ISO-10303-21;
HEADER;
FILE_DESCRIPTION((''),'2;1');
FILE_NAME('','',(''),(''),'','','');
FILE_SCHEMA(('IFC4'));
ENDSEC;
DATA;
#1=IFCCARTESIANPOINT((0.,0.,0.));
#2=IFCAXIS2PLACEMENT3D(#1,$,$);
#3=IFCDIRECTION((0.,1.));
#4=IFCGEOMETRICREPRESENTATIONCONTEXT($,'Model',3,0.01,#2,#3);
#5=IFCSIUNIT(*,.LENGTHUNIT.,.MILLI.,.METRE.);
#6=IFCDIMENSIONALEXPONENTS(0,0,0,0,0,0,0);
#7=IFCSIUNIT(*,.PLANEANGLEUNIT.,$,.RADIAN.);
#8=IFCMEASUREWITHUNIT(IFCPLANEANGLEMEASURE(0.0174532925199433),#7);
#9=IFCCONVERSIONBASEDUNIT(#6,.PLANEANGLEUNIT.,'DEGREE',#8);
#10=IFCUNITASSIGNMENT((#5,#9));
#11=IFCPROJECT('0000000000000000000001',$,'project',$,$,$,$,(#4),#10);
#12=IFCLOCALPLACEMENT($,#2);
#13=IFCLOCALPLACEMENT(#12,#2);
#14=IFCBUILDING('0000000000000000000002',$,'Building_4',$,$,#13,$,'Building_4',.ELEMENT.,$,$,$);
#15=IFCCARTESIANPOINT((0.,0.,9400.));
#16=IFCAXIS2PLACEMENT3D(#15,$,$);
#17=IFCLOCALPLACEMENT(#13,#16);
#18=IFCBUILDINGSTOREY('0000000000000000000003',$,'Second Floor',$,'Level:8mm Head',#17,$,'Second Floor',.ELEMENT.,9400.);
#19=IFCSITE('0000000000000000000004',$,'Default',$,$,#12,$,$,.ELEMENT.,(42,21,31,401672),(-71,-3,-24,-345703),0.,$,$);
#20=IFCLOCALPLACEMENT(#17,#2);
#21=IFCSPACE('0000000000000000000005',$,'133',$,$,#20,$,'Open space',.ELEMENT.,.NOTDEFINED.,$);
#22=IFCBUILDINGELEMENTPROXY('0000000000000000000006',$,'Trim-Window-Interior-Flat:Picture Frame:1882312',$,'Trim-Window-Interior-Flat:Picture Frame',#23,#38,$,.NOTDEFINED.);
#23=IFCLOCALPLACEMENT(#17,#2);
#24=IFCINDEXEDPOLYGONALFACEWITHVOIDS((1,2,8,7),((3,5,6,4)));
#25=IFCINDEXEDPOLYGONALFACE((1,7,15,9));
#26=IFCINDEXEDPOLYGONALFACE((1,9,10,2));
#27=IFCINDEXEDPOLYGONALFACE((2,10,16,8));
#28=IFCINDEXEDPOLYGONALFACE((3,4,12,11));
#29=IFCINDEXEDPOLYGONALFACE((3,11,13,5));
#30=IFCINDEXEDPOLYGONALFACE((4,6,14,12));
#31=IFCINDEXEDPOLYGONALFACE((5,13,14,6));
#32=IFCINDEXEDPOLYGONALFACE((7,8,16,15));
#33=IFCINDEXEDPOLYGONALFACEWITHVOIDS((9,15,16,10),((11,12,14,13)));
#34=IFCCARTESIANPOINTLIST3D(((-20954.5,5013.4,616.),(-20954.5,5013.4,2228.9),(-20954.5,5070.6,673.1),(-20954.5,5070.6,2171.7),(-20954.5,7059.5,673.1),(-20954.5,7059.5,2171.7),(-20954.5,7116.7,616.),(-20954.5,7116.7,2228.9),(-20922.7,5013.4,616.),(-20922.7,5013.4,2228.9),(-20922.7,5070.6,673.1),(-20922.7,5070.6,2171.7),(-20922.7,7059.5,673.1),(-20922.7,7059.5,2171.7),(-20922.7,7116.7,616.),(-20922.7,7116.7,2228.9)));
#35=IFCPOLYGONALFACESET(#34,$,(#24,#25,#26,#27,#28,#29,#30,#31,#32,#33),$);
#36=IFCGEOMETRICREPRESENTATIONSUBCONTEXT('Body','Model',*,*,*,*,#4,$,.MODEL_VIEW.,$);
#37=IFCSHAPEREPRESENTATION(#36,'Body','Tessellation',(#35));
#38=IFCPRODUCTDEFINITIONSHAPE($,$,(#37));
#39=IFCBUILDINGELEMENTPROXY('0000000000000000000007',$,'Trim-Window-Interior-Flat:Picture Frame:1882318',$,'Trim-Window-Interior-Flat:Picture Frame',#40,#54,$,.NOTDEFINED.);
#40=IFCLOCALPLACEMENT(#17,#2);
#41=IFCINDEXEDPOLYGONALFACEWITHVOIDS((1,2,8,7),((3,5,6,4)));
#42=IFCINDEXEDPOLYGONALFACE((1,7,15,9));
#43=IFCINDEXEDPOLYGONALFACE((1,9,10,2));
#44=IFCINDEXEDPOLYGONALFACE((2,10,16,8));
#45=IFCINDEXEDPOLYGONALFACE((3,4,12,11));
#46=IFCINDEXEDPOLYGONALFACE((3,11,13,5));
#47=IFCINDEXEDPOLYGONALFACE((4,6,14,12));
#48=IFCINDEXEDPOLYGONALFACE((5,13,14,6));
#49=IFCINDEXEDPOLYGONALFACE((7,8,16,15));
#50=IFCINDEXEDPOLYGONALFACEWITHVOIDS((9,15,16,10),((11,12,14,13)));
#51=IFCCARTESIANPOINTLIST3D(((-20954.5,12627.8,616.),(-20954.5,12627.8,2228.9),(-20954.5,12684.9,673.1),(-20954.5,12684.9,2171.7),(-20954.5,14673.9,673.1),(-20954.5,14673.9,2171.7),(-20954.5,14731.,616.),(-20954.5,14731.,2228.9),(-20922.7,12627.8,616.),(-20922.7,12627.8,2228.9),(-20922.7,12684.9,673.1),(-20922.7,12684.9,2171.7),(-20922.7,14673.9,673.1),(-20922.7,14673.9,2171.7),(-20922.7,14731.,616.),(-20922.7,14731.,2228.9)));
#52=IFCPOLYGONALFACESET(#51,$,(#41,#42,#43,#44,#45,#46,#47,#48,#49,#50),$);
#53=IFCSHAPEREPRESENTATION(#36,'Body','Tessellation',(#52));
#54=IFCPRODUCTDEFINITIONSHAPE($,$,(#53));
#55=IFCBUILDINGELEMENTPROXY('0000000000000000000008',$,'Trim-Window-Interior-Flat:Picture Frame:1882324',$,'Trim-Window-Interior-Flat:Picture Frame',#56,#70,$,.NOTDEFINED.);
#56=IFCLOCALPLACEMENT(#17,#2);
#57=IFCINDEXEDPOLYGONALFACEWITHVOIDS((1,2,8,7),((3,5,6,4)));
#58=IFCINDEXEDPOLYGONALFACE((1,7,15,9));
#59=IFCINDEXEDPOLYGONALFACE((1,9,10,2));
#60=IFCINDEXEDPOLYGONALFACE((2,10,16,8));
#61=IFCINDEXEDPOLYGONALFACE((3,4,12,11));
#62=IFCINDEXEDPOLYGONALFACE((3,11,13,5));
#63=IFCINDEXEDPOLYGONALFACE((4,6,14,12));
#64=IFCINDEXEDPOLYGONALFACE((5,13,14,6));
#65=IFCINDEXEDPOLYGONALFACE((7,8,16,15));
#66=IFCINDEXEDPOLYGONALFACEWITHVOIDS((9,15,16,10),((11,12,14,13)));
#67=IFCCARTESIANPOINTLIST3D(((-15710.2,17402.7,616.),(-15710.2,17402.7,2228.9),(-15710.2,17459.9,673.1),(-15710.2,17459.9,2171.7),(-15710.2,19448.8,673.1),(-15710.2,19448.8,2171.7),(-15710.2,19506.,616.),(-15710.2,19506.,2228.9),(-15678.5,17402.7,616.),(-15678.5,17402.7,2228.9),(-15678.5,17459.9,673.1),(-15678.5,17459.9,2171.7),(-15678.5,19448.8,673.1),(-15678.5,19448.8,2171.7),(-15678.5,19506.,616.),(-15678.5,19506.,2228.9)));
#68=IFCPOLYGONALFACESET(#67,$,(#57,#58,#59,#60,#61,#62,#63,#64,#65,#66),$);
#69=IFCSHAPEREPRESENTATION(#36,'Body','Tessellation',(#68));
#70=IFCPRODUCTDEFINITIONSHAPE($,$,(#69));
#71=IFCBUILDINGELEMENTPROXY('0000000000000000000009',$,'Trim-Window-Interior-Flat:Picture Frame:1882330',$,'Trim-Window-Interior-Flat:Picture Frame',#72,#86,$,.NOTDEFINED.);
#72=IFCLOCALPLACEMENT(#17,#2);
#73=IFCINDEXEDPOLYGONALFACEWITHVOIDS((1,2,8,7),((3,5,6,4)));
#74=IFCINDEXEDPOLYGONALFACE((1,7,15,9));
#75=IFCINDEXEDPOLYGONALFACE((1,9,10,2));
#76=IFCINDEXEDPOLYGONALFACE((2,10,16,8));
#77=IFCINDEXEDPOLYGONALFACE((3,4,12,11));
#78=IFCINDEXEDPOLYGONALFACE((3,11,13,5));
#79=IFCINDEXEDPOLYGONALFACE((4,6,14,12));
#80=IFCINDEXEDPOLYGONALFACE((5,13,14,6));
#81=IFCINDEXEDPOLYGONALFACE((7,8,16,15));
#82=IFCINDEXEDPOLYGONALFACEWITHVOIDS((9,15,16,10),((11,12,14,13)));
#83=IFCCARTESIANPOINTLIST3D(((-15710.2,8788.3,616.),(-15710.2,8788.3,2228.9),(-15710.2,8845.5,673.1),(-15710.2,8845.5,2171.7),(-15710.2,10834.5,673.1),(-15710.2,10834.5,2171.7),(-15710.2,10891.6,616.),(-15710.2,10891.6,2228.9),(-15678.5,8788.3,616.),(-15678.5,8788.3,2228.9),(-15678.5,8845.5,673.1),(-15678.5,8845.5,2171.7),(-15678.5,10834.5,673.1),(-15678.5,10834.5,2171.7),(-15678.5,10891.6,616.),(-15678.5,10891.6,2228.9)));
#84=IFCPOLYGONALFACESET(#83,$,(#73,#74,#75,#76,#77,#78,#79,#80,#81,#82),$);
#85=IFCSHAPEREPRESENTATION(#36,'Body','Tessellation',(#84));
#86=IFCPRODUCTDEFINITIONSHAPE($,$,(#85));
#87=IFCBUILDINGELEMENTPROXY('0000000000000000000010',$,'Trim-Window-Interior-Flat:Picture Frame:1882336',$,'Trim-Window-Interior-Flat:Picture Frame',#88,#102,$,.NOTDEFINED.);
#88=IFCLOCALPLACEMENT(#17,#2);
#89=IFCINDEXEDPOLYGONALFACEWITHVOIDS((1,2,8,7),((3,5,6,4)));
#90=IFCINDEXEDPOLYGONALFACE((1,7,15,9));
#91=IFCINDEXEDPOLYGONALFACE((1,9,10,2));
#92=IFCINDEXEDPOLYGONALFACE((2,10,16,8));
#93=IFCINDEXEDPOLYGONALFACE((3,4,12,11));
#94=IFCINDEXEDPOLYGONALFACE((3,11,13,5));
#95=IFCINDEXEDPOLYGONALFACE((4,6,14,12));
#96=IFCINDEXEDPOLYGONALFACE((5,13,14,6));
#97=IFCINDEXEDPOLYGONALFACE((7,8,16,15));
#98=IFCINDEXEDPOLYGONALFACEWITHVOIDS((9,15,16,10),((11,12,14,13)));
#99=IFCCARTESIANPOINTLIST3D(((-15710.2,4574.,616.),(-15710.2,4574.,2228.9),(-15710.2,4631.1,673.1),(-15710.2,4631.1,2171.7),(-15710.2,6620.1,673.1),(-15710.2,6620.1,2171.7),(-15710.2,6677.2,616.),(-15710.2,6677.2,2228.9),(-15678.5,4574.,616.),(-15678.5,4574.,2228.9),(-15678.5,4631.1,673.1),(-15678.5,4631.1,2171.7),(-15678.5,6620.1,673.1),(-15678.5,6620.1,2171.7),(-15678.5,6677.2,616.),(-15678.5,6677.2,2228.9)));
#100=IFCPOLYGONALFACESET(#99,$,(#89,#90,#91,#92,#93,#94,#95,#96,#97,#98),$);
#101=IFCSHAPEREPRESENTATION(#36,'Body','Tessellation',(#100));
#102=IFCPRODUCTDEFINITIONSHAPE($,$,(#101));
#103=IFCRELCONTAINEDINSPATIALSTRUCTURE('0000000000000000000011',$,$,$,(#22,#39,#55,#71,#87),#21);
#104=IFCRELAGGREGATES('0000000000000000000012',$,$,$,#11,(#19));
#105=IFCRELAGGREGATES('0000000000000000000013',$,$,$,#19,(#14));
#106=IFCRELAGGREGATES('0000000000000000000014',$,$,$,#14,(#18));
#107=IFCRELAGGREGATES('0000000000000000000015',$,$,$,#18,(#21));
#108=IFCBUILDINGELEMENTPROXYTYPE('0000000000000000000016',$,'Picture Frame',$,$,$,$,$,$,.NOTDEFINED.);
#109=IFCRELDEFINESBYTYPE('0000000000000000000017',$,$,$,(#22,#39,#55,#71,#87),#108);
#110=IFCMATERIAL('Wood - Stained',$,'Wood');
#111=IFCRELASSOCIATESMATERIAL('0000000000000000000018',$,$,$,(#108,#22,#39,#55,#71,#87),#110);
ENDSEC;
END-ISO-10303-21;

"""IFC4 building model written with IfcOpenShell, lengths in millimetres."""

from ifc_helpers import new_model, entity, si_unit, converted_unit, direction, frame, origin, place, context, subcontext, project, spatial, indexed_curve, outline, extrude, source, transform, mapped, material, type_object, type_shapes, element, save


model = new_model("IFC4")

# Units and contexts
model_context = context("Model", 3, precision=0.01, world=origin(), true_north=direction((0.0, 1.0)))
body_context = subcontext(model_context, "Body", "Model", "MODEL_VIEW")
ifc_project = project(units=[si_unit("LENGTHUNIT", "METRE", prefix="MILLI"), converted_unit("PLANEANGLEUNIT", "DEGREE", entity("IfcPlaneAngleMeasure", 0.0174532925199433), si_unit("PLANEANGLEUNIT", "RADIAN"), dimensions=[0, 0, 0, 0, 0, 0, 0])], contexts=[model_context])

# Site, building, storey
site_placement = place(None, origin())
site = spatial("IfcSite", under=ifc_project, at=site_placement, Name="Default", CompositionType="ELEMENT", RefLatitude=(42, 21, 31, 401672), RefLongitude=(-71, -3, -24, -345703), RefElevation=0.0)
building_placement = place(site_placement, origin())
building = spatial("IfcBuilding", under=site, at=building_placement, Name="Building_4", LongName="Building_4", CompositionType="ELEMENT")
storey_placement = place(building_placement, frame((0.0, 0.0, 9400.0)))
storey = spatial("IfcBuildingStorey", under=building, at=storey_placement, Name="Second Floor", ObjectType="Level:8mm Head", LongName="Second Floor", CompositionType="ELEMENT", Elevation=9400.0)

# Shared definitions
ifc_material_1 = material(Name="Wood - Stained", Category="Wood")

# Shared definitions
space_placement = place(storey_placement, origin())
space = spatial("IfcSpace", under=storey, at=space_placement, Name="133", LongName="Open space", CompositionType="ELEMENT", PredefinedType="NOTDEFINED")

# Building element proxies
building_element_proxy_type_1 = type_object("IfcBuildingElementProxyType", Name="Picture Frame", PredefinedType="NOTDEFINED", material=ifc_material_1)
shared_shape_1 = source(origin(), body_context, "Body", "SweptSolid", [
    extrude(outline(indexed_curve([(-1051.6, -806.4), (1051.6, -806.4), (1051.6, 806.4), (-1051.6, 806.4), (-1051.6, -806.4)], self_intersect=False), holes=[indexed_curve([(-994.5, -749.3), (-994.5, 749.3), (994.5, 749.3), (994.5, -749.3), (-994.5, -749.3)], self_intersect=False)]), frame((0.0, -762.0, 0.0), z_axis=(0.0, 0.0, 1.0), x_axis=(-1.0, 0.0, 0.0)), (0.0, 0.0, 1.0), 31.8),
])
type_shapes(building_element_proxy_type_1, [shared_shape_1])
for number, where, z_axis, x_axis, name in (
    (1, (-20954.5, 6065.0, 2184.4), (1.0, 0.0, 0.0), (0.0, 1.0, 0.0), "Trim-Window-Interior-Flat:Picture Frame:1882312"),
    (2, (-20954.5, 13679.4, 2184.4), (1.0, 0.0, 0.0), (0.0, 1.0, 0.0), "Trim-Window-Interior-Flat:Picture Frame:1882318"),
    (3, (-15678.5, 18454.3, 2184.4), (-1.0, 0.0, 0.0), (0.0, -1.0, 0.0), "Trim-Window-Interior-Flat:Picture Frame:1882324"),
    (4, (-15678.5, 9840.0, 2184.4), (-1.0, 0.0, 0.0), (0.0, -1.0, 0.0), "Trim-Window-Interior-Flat:Picture Frame:1882330"),
    (5, (-15678.5, 5625.6, 2184.4), (-1.0, 0.0, 0.0), (0.0, -1.0, 0.0), "Trim-Window-Interior-Flat:Picture Frame:1882336"),
):
    element("IfcBuildingElementProxy", number, at=place(space_placement, frame(where, z_axis=z_axis, x_axis=x_axis)), inside=space, type_object=building_element_proxy_type_1, material=ifc_material_1, Name=name, ObjectType="Trim-Window-Interior-Flat:Picture Frame", PredefinedType="NOTDEFINED", context=body_context, shape_type="MappedRepresentation", body=[
        mapped(shared_shape_1, transform((0.0, 0.0, 0.0), scale=1.0)),
    ])

save(model, "model.ifc")
